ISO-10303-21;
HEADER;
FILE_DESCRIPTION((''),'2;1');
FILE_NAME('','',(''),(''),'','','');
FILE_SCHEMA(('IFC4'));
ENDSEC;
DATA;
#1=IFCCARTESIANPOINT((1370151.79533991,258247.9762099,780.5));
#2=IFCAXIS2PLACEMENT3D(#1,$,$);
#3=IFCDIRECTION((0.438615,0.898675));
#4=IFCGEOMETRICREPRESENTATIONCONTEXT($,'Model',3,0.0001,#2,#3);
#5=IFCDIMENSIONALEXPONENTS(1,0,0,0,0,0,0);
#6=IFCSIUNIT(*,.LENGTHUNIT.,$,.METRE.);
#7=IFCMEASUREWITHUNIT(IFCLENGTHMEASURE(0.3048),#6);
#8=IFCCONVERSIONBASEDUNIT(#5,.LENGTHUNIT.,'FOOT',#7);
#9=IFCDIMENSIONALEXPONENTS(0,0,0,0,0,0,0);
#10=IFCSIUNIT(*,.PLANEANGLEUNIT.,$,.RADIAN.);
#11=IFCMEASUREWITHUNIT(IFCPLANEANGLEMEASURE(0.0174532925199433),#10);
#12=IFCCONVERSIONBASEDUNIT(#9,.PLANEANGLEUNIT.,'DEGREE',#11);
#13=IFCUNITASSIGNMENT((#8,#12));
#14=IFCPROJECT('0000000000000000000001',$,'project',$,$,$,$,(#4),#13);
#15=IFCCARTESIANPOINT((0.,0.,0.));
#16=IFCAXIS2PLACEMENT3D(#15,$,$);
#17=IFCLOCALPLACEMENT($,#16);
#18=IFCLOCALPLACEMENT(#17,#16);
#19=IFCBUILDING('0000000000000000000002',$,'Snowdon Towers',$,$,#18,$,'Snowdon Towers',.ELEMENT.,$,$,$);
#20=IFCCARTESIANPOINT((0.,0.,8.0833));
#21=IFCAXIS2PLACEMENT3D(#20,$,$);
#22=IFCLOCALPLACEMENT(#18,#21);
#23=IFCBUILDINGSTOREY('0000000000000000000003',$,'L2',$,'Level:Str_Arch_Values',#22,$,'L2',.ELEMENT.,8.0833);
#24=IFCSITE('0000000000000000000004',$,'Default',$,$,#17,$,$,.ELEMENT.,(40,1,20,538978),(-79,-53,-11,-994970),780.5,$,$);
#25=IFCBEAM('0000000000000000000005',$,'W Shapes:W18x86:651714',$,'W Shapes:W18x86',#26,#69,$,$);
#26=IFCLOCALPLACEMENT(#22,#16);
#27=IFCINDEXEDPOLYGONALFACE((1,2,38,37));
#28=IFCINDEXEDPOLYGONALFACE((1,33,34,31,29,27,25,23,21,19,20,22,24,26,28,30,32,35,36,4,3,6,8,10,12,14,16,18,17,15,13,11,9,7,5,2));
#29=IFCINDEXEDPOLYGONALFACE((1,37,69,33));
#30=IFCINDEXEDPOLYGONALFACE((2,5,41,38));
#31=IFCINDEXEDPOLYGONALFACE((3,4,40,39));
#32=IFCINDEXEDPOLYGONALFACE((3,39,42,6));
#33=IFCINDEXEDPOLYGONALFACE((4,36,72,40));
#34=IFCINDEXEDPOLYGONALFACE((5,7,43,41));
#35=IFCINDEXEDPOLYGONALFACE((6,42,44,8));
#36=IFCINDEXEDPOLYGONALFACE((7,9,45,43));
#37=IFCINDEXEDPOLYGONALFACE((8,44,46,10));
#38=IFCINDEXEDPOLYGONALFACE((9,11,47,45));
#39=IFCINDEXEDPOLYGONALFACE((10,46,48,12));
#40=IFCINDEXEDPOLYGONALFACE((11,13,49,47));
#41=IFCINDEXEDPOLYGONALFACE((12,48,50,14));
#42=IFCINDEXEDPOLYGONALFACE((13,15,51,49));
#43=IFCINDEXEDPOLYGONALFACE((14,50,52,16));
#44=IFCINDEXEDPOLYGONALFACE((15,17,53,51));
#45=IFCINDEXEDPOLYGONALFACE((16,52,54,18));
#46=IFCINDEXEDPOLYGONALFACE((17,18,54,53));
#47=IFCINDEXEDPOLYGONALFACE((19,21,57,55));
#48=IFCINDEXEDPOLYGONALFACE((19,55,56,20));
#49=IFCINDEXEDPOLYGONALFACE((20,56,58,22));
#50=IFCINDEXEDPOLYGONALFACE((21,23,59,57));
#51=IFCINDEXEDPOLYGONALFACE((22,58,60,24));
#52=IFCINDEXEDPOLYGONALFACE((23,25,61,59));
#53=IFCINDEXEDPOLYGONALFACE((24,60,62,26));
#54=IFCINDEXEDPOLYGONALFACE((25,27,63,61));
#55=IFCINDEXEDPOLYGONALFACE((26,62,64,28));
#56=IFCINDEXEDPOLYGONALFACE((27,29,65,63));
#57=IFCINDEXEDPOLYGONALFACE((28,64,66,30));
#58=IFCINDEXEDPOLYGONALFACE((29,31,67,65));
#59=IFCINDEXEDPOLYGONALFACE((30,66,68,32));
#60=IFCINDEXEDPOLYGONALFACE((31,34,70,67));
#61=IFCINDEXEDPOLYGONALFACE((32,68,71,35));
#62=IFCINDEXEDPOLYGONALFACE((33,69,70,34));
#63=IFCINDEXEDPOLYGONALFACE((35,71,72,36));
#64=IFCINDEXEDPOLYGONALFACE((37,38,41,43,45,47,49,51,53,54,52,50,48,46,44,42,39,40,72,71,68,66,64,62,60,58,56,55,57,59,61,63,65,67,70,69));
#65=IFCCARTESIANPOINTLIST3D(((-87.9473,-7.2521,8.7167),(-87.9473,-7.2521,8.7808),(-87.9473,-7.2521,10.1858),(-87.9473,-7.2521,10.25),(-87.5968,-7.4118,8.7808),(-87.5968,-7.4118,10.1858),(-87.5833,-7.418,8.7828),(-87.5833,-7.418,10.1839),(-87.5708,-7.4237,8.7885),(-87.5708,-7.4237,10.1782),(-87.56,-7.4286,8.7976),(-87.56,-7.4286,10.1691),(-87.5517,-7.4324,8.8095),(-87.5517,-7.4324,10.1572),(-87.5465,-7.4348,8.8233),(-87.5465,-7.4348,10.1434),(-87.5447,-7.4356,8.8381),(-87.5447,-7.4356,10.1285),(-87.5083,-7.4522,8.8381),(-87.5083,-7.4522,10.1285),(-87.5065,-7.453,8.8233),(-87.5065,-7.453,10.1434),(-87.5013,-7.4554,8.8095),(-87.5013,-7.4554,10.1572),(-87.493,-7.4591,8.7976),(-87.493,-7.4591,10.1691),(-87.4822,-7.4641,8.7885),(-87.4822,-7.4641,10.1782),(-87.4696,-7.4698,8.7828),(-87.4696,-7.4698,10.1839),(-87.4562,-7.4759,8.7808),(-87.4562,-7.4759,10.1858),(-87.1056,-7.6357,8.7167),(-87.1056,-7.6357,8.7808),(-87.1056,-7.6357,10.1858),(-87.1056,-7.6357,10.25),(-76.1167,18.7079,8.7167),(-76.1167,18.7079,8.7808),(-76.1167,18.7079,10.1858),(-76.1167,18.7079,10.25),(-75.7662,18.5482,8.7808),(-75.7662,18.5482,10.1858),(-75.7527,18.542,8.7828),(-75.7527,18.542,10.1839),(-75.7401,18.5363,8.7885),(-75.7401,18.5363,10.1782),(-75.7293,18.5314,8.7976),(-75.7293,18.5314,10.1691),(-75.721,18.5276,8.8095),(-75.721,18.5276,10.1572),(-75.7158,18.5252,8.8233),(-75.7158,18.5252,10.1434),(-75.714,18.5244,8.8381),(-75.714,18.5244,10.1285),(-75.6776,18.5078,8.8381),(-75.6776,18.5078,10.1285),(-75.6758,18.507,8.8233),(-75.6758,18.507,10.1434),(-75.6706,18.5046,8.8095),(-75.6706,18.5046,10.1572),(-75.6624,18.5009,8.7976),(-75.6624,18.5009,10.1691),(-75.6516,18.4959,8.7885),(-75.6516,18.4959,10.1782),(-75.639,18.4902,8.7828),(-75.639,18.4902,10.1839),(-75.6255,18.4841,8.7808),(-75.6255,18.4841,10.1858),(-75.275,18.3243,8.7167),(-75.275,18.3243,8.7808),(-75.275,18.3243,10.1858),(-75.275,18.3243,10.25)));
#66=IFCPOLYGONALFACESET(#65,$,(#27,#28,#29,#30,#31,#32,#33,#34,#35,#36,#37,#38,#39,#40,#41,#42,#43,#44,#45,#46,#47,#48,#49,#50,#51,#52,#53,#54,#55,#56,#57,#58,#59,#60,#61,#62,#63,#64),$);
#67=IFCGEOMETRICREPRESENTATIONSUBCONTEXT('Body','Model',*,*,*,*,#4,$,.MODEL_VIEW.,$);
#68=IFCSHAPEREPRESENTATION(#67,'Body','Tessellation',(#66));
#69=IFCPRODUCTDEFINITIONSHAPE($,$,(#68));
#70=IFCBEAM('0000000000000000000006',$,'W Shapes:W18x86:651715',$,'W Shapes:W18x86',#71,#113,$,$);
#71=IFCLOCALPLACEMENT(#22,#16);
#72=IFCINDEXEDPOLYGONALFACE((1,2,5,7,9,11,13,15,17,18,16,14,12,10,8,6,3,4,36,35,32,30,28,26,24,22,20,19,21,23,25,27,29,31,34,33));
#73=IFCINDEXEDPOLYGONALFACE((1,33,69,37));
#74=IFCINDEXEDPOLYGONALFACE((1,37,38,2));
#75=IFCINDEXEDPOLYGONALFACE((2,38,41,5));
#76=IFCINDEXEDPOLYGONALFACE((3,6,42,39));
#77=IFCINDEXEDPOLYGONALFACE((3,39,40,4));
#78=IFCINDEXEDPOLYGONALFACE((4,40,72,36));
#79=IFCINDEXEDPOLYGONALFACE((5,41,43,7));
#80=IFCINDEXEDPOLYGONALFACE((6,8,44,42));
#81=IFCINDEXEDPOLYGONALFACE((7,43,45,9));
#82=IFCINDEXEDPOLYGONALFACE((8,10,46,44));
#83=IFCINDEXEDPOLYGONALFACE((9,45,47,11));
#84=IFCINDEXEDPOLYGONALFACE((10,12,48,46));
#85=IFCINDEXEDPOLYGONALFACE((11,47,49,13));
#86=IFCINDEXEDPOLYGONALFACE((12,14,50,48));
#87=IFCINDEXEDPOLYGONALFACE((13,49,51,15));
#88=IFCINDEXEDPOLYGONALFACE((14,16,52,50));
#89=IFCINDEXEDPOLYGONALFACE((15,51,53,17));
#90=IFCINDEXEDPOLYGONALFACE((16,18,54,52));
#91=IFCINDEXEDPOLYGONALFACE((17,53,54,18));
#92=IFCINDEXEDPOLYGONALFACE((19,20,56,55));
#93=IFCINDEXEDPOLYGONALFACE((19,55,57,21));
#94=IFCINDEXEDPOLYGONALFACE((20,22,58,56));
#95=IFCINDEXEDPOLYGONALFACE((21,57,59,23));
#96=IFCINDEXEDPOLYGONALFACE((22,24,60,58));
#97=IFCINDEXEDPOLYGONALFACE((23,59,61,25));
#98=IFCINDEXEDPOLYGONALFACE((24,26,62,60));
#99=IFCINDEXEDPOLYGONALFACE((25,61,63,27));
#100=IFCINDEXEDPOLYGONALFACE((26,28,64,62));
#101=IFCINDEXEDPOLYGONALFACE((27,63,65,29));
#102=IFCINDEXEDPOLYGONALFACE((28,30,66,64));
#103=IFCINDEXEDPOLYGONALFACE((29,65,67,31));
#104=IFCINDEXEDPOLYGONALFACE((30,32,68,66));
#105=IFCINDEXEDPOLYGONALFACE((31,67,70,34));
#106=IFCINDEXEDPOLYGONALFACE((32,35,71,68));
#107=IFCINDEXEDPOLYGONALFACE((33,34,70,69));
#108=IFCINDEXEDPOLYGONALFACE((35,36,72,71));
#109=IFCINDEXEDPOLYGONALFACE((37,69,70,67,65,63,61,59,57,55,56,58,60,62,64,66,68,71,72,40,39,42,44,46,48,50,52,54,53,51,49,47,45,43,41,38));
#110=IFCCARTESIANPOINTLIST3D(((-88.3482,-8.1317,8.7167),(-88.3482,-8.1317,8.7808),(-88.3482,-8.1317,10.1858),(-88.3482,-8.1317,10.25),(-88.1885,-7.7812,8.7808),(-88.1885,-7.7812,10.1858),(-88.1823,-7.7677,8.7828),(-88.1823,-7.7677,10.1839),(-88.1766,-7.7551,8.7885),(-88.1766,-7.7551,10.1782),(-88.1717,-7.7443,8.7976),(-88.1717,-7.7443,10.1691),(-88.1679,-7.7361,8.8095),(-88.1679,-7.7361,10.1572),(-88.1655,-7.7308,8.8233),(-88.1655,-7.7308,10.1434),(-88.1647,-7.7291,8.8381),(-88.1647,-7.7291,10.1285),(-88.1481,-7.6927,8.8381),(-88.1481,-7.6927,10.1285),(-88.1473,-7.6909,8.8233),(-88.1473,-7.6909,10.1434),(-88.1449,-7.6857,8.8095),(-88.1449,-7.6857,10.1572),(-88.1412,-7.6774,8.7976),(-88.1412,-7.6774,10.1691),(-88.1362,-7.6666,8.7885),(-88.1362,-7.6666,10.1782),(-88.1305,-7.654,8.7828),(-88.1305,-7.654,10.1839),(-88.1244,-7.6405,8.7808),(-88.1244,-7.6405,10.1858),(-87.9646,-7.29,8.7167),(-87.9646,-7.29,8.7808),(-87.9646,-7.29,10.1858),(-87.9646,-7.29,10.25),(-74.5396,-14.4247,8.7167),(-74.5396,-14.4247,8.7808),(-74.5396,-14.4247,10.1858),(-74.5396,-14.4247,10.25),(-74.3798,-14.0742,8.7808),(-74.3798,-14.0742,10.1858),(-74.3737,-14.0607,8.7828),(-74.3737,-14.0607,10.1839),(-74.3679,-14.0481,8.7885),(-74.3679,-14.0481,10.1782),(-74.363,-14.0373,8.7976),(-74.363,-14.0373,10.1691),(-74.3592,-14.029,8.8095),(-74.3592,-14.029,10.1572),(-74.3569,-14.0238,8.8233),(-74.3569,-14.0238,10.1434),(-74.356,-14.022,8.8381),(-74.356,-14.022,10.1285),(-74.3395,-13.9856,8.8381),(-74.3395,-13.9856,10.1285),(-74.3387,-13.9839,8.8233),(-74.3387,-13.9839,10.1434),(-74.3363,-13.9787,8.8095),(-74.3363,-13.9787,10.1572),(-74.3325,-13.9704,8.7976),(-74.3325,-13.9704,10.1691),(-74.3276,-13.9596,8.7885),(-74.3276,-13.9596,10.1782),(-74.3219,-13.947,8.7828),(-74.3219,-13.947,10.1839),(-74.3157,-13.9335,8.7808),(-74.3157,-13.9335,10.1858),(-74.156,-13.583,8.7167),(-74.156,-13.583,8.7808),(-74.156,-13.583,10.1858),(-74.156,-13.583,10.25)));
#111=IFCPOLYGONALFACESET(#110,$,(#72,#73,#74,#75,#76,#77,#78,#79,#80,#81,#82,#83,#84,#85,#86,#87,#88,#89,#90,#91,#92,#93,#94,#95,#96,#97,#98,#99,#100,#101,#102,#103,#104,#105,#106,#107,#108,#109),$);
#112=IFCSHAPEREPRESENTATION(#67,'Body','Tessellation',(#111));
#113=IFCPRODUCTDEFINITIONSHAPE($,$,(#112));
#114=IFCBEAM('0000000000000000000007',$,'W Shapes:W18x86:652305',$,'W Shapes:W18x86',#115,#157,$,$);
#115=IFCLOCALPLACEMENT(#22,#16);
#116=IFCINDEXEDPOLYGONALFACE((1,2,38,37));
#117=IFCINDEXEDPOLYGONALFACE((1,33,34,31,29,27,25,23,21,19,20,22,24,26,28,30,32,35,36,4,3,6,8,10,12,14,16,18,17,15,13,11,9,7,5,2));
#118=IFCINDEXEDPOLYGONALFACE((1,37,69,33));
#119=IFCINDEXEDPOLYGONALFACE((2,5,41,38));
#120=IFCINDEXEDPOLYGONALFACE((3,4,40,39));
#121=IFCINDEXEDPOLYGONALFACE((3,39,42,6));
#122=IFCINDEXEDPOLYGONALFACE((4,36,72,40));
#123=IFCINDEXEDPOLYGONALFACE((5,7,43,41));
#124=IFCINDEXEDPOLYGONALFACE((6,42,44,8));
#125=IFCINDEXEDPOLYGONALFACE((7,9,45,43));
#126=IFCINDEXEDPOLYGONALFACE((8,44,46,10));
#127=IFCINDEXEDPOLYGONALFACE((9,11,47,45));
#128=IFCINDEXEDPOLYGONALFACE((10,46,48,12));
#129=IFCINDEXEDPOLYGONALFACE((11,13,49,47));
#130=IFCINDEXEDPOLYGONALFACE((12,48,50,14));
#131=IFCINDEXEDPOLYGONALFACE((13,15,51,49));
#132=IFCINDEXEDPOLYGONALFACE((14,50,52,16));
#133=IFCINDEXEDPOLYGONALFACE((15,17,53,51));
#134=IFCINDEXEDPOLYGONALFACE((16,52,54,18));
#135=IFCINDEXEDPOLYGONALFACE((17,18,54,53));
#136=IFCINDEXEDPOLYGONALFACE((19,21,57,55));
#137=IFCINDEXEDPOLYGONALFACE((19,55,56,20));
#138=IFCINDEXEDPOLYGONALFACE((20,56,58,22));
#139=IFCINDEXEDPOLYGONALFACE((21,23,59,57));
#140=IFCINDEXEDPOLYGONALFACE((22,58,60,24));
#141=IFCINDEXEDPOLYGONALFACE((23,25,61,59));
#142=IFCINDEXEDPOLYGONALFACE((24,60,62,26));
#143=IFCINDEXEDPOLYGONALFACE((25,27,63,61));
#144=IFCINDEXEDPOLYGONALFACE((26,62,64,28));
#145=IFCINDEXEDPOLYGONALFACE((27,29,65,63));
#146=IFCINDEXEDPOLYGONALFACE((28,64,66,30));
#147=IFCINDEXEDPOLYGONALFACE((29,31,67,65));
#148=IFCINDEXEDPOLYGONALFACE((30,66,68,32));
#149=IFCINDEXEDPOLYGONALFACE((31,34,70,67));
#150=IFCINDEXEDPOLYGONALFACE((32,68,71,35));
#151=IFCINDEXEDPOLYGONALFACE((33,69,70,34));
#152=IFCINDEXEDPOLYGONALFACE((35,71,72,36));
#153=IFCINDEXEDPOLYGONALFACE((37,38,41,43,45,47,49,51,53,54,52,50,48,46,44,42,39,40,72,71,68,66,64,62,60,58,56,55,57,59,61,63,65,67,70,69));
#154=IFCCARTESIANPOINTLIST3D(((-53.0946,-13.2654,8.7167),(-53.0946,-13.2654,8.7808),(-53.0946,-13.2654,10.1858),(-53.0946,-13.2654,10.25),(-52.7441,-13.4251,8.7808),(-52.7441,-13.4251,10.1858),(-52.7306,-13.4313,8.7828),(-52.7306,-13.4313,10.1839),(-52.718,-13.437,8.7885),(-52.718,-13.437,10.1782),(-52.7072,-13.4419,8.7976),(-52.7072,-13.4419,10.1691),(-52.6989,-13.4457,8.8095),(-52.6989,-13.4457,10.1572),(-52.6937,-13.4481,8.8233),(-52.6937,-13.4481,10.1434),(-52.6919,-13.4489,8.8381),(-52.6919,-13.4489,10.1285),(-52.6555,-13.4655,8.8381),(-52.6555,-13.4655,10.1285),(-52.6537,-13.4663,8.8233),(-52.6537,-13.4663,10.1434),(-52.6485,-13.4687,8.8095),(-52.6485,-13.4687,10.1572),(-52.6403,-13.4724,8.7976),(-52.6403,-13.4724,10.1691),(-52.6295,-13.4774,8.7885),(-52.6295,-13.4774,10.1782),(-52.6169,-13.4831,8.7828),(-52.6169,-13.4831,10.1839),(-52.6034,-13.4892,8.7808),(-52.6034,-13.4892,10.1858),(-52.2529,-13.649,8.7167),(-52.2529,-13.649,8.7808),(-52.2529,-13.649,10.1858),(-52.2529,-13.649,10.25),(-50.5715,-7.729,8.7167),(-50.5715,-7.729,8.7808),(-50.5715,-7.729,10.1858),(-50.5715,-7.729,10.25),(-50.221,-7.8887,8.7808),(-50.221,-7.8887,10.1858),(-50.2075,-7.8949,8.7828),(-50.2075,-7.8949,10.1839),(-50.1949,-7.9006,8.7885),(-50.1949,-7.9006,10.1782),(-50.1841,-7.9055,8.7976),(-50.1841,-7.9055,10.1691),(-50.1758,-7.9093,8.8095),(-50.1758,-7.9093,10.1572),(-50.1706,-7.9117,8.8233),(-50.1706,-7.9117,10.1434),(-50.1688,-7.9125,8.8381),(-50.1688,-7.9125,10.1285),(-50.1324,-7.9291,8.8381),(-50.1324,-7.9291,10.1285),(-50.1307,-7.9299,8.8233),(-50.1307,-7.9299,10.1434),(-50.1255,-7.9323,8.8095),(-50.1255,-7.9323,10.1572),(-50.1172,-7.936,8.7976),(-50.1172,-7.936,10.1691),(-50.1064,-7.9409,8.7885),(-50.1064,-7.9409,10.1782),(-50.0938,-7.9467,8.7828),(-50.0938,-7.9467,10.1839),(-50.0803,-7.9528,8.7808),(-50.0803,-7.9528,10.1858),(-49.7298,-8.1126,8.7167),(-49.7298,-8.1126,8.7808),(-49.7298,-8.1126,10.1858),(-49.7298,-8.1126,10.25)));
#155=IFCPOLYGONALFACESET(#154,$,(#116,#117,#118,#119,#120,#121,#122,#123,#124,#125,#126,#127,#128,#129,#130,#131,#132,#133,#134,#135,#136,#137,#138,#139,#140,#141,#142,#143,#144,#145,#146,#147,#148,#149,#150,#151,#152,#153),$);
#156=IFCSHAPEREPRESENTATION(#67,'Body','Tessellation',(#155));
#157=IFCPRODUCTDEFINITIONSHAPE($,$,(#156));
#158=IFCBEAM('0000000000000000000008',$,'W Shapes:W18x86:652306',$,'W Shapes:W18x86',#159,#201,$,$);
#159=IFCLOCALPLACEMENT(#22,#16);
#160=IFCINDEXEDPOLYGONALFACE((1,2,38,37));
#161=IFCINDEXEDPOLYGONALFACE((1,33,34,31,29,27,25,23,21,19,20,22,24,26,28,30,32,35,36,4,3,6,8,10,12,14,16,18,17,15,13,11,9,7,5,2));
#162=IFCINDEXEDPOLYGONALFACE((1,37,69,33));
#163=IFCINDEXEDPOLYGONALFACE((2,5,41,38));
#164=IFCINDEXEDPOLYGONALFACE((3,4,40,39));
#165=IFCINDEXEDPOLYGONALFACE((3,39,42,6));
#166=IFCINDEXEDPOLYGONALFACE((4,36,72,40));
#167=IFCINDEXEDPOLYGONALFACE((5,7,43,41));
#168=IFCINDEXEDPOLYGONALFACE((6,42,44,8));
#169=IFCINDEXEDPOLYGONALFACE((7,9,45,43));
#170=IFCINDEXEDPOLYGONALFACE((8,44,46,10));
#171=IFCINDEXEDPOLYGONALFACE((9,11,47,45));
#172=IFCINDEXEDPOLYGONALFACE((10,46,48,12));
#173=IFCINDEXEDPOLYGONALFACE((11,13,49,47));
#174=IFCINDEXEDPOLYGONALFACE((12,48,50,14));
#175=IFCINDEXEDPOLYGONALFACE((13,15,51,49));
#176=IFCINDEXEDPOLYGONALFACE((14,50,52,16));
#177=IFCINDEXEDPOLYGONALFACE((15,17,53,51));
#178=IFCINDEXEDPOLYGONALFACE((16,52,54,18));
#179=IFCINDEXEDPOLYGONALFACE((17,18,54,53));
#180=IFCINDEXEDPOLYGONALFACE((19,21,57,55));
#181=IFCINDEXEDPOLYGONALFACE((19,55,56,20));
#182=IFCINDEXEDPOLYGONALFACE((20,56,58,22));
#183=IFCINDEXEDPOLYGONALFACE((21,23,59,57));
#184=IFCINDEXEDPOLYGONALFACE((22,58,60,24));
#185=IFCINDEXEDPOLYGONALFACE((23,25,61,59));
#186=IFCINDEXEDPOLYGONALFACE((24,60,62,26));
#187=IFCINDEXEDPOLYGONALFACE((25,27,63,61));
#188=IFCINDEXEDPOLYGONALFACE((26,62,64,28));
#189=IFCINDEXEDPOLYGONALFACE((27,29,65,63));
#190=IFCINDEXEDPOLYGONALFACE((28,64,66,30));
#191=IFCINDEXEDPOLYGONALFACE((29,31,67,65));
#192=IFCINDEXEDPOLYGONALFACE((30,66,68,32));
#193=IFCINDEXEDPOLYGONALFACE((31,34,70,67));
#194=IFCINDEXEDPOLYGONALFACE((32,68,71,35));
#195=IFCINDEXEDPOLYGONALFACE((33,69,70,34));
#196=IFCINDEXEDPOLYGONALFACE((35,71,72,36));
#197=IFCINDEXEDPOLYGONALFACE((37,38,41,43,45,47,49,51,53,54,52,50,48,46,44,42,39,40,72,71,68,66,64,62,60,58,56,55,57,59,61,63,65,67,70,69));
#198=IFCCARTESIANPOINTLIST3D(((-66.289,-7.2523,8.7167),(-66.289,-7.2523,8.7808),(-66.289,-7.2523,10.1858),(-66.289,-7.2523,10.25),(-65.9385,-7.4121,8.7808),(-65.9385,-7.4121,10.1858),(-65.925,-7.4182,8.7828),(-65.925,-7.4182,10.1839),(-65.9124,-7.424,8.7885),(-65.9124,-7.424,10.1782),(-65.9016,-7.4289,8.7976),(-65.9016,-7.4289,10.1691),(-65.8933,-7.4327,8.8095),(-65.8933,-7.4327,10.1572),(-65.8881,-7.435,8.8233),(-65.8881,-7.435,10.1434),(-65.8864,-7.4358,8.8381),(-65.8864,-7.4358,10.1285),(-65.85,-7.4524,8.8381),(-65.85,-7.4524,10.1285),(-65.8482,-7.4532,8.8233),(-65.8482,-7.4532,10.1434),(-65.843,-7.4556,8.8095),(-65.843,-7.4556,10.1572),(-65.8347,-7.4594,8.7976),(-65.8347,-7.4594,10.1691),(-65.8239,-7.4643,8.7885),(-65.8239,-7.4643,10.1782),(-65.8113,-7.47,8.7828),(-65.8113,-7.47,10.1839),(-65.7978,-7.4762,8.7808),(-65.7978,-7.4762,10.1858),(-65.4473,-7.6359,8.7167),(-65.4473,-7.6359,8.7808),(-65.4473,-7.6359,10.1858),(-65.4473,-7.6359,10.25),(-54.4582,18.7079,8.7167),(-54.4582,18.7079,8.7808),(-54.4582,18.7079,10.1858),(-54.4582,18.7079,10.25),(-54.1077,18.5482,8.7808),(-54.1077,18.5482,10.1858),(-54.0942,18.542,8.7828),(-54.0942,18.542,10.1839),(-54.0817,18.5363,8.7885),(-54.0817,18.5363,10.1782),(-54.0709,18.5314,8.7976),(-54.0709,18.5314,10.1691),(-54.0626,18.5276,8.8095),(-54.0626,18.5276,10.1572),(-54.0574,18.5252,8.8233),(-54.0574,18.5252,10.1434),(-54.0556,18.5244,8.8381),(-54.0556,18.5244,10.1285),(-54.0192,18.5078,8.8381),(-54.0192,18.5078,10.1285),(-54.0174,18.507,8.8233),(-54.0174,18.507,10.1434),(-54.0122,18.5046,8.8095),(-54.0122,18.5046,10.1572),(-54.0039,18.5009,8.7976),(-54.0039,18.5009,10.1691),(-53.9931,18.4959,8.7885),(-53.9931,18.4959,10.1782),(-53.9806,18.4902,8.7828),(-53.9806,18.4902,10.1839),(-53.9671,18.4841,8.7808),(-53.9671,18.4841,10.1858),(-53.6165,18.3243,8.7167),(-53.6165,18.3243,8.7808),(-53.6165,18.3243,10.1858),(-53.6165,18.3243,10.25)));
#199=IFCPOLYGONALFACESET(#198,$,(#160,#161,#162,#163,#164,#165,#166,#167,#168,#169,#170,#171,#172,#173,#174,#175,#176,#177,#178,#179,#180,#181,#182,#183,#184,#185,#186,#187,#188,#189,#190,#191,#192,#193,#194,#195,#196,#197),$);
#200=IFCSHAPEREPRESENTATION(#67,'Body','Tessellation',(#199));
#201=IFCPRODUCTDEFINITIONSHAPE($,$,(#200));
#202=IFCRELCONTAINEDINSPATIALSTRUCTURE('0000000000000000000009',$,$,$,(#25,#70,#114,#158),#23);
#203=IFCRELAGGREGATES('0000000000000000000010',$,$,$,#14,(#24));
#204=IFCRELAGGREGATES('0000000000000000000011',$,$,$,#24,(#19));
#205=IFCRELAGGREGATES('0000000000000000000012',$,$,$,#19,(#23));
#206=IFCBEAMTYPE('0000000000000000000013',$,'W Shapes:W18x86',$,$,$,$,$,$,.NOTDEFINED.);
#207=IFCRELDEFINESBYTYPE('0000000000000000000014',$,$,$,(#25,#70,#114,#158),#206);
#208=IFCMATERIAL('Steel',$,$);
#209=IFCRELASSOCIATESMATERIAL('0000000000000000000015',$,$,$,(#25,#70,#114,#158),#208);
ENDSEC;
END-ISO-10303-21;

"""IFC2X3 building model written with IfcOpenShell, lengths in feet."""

from ifc_helpers import new_model, entity, si_unit, converted_unit, direction, frame, frame_2d, origin, place, context, subcontext, project, spatial, i_section, extrude, material, type_object, element, save


model = new_model("IFC2X3")

# Units and contexts
model_context = context("Model", 3, precision=0.0001, world=frame((1370151.79533991, 258247.9762099, 780.5)), true_north=direction((0.438615, 0.898675)))
body_context = subcontext(model_context, "Body", "Model", "MODEL_VIEW")
ifc_project = project(units=[converted_unit("LENGTHUNIT", "FOOT", entity("IfcLengthMeasure", 0.3048), si_unit("LENGTHUNIT", "METRE"), dimensions=[1, 0, 0, 0, 0, 0, 0]), converted_unit("PLANEANGLEUNIT", "DEGREE", entity("IfcPlaneAngleMeasure", 0.0174532925199433), si_unit("PLANEANGLEUNIT", "RADIAN"), dimensions=[0, 0, 0, 0, 0, 0, 0])], contexts=[model_context])

# Site, building, storey
site_placement = place(None, origin())
site = spatial("IfcSite", under=ifc_project, at=site_placement, Name="Default", CompositionType="ELEMENT", RefLatitude=(40, 1, 20, 538978), RefLongitude=(-79, -53, -11, -994970), RefElevation=780.5)
building_placement = place(site_placement, origin())
building = spatial("IfcBuilding", under=site, at=building_placement, Name="Snowdon Towers", LongName="Snowdon Towers", CompositionType="ELEMENT")
storey_placement = place(building_placement, frame((0.0, 0.0, 8.0833)))
storey = spatial("IfcBuildingStorey", under=building, at=storey_placement, Name="L2", ObjectType="Level:Str_Arch_Values", LongName="L2", CompositionType="ELEMENT", Elevation=8.0833)

# Shared definitions
ifc_material_1 = material(Name="Steel")

# Beams
beam_type_1 = type_object("IfcBeamType", Name="W Shapes:W18x86", PredefinedType="NOTDEFINED")
beam_1_placement = place(storey_placement, frame((-87.7356, -7.9027, 10.25), z_axis=(0.0, 0.0, 1.0), x_axis=(0.414693, 0.909961, 0.0)))
element("IfcBeam", 1, at=beam_1_placement, inside=storey, type_object=beam_type_1, material=ifc_material_1, Name="W Shapes:W18x86:651714", ObjectType="W Shapes:W18x86", context=body_context, shape_type="SweptSolid", body=[
    extrude(i_section(OverallWidth=0.925, OverallDepth=1.5333, WebThickness=0.04, FlangeThickness=0.0642, FilletRadius=0.0573, at=frame_2d((0.0, 0.0), x_axis=(0.0, 1.0))), frame((0.5042, 0.0, -0.7667), z_axis=(1.0, 0.0, 0.0), x_axis=(0.0, 0.0, -1.0)), (0.0, 0.0, 1.0), 28.5287),
])
beam_2_placement = place(storey_placement, frame((-87.7356, -7.9027, 10.25), z_axis=(0.0, 0.0, 1.0), x_axis=(0.909961, -0.414693, 0.0)))
element("IfcBeam", 2, at=beam_2_placement, inside=storey, type_object=beam_type_1, material=ifc_material_1, Name="W Shapes:W18x86:651715", ObjectType="W Shapes:W18x86", context=body_context, shape_type="SweptSolid", body=[
    extrude(i_section(OverallWidth=0.925, OverallDepth=1.5333, WebThickness=0.04, FlangeThickness=0.0642, FilletRadius=0.0573, at=frame_2d((0.0, 0.0), x_axis=(0.0, 1.0))), frame((-0.4625, 0.0, -0.7667), z_axis=(1.0, 0.0, 0.0), x_axis=(0.0, 0.0, -1.0)), (0.0, 0.0, 1.0), 15.175),
])
beam_3_placement = place(storey_placement, frame((-52.8828, -13.916, 10.25), z_axis=(0.0, 0.0, 1.0), x_axis=(0.414693, 0.909961, 0.0)))
element("IfcBeam", 3, at=beam_3_placement, inside=storey, type_object=beam_type_1, material=ifc_material_1, Name="W Shapes:W18x86:652305", ObjectType="W Shapes:W18x86", context=body_context, shape_type="SweptSolid", body=[
    extrude(i_section(OverallWidth=0.925, OverallDepth=1.5333, WebThickness=0.04, FlangeThickness=0.0642, FilletRadius=0.0573, at=frame_2d((0.0, 0.0), x_axis=(0.0, 1.0))), frame((0.5042, 0.0, -0.7667), z_axis=(1.0, 0.0, 0.0), x_axis=(0.0, 0.0, -1.0)), (0.0, 0.0, 1.0), 6.0842),
])
beam_4_placement = place(storey_placement, frame((-66.0772, -7.9029, 10.25), z_axis=(0.0, 0.0, 1.0), x_axis=(0.414693, 0.909961, 0.0)))
element("IfcBeam", 4, at=beam_4_placement, inside=storey, type_object=beam_type_1, material=ifc_material_1, Name="W Shapes:W18x86:652306", ObjectType="W Shapes:W18x86", context=body_context, shape_type="SweptSolid", body=[
    extrude(i_section(OverallWidth=0.925, OverallDepth=1.5333, WebThickness=0.04, FlangeThickness=0.0642, FilletRadius=0.0573, at=frame_2d((0.0, 0.0), x_axis=(0.0, 1.0))), frame((0.5042, 0.0, -0.7667), z_axis=(1.0, 0.0, 0.0), x_axis=(0.0, 0.0, -1.0)), (0.0, 0.0, 1.0), 28.529),
])

save(model, "model.ifc")
